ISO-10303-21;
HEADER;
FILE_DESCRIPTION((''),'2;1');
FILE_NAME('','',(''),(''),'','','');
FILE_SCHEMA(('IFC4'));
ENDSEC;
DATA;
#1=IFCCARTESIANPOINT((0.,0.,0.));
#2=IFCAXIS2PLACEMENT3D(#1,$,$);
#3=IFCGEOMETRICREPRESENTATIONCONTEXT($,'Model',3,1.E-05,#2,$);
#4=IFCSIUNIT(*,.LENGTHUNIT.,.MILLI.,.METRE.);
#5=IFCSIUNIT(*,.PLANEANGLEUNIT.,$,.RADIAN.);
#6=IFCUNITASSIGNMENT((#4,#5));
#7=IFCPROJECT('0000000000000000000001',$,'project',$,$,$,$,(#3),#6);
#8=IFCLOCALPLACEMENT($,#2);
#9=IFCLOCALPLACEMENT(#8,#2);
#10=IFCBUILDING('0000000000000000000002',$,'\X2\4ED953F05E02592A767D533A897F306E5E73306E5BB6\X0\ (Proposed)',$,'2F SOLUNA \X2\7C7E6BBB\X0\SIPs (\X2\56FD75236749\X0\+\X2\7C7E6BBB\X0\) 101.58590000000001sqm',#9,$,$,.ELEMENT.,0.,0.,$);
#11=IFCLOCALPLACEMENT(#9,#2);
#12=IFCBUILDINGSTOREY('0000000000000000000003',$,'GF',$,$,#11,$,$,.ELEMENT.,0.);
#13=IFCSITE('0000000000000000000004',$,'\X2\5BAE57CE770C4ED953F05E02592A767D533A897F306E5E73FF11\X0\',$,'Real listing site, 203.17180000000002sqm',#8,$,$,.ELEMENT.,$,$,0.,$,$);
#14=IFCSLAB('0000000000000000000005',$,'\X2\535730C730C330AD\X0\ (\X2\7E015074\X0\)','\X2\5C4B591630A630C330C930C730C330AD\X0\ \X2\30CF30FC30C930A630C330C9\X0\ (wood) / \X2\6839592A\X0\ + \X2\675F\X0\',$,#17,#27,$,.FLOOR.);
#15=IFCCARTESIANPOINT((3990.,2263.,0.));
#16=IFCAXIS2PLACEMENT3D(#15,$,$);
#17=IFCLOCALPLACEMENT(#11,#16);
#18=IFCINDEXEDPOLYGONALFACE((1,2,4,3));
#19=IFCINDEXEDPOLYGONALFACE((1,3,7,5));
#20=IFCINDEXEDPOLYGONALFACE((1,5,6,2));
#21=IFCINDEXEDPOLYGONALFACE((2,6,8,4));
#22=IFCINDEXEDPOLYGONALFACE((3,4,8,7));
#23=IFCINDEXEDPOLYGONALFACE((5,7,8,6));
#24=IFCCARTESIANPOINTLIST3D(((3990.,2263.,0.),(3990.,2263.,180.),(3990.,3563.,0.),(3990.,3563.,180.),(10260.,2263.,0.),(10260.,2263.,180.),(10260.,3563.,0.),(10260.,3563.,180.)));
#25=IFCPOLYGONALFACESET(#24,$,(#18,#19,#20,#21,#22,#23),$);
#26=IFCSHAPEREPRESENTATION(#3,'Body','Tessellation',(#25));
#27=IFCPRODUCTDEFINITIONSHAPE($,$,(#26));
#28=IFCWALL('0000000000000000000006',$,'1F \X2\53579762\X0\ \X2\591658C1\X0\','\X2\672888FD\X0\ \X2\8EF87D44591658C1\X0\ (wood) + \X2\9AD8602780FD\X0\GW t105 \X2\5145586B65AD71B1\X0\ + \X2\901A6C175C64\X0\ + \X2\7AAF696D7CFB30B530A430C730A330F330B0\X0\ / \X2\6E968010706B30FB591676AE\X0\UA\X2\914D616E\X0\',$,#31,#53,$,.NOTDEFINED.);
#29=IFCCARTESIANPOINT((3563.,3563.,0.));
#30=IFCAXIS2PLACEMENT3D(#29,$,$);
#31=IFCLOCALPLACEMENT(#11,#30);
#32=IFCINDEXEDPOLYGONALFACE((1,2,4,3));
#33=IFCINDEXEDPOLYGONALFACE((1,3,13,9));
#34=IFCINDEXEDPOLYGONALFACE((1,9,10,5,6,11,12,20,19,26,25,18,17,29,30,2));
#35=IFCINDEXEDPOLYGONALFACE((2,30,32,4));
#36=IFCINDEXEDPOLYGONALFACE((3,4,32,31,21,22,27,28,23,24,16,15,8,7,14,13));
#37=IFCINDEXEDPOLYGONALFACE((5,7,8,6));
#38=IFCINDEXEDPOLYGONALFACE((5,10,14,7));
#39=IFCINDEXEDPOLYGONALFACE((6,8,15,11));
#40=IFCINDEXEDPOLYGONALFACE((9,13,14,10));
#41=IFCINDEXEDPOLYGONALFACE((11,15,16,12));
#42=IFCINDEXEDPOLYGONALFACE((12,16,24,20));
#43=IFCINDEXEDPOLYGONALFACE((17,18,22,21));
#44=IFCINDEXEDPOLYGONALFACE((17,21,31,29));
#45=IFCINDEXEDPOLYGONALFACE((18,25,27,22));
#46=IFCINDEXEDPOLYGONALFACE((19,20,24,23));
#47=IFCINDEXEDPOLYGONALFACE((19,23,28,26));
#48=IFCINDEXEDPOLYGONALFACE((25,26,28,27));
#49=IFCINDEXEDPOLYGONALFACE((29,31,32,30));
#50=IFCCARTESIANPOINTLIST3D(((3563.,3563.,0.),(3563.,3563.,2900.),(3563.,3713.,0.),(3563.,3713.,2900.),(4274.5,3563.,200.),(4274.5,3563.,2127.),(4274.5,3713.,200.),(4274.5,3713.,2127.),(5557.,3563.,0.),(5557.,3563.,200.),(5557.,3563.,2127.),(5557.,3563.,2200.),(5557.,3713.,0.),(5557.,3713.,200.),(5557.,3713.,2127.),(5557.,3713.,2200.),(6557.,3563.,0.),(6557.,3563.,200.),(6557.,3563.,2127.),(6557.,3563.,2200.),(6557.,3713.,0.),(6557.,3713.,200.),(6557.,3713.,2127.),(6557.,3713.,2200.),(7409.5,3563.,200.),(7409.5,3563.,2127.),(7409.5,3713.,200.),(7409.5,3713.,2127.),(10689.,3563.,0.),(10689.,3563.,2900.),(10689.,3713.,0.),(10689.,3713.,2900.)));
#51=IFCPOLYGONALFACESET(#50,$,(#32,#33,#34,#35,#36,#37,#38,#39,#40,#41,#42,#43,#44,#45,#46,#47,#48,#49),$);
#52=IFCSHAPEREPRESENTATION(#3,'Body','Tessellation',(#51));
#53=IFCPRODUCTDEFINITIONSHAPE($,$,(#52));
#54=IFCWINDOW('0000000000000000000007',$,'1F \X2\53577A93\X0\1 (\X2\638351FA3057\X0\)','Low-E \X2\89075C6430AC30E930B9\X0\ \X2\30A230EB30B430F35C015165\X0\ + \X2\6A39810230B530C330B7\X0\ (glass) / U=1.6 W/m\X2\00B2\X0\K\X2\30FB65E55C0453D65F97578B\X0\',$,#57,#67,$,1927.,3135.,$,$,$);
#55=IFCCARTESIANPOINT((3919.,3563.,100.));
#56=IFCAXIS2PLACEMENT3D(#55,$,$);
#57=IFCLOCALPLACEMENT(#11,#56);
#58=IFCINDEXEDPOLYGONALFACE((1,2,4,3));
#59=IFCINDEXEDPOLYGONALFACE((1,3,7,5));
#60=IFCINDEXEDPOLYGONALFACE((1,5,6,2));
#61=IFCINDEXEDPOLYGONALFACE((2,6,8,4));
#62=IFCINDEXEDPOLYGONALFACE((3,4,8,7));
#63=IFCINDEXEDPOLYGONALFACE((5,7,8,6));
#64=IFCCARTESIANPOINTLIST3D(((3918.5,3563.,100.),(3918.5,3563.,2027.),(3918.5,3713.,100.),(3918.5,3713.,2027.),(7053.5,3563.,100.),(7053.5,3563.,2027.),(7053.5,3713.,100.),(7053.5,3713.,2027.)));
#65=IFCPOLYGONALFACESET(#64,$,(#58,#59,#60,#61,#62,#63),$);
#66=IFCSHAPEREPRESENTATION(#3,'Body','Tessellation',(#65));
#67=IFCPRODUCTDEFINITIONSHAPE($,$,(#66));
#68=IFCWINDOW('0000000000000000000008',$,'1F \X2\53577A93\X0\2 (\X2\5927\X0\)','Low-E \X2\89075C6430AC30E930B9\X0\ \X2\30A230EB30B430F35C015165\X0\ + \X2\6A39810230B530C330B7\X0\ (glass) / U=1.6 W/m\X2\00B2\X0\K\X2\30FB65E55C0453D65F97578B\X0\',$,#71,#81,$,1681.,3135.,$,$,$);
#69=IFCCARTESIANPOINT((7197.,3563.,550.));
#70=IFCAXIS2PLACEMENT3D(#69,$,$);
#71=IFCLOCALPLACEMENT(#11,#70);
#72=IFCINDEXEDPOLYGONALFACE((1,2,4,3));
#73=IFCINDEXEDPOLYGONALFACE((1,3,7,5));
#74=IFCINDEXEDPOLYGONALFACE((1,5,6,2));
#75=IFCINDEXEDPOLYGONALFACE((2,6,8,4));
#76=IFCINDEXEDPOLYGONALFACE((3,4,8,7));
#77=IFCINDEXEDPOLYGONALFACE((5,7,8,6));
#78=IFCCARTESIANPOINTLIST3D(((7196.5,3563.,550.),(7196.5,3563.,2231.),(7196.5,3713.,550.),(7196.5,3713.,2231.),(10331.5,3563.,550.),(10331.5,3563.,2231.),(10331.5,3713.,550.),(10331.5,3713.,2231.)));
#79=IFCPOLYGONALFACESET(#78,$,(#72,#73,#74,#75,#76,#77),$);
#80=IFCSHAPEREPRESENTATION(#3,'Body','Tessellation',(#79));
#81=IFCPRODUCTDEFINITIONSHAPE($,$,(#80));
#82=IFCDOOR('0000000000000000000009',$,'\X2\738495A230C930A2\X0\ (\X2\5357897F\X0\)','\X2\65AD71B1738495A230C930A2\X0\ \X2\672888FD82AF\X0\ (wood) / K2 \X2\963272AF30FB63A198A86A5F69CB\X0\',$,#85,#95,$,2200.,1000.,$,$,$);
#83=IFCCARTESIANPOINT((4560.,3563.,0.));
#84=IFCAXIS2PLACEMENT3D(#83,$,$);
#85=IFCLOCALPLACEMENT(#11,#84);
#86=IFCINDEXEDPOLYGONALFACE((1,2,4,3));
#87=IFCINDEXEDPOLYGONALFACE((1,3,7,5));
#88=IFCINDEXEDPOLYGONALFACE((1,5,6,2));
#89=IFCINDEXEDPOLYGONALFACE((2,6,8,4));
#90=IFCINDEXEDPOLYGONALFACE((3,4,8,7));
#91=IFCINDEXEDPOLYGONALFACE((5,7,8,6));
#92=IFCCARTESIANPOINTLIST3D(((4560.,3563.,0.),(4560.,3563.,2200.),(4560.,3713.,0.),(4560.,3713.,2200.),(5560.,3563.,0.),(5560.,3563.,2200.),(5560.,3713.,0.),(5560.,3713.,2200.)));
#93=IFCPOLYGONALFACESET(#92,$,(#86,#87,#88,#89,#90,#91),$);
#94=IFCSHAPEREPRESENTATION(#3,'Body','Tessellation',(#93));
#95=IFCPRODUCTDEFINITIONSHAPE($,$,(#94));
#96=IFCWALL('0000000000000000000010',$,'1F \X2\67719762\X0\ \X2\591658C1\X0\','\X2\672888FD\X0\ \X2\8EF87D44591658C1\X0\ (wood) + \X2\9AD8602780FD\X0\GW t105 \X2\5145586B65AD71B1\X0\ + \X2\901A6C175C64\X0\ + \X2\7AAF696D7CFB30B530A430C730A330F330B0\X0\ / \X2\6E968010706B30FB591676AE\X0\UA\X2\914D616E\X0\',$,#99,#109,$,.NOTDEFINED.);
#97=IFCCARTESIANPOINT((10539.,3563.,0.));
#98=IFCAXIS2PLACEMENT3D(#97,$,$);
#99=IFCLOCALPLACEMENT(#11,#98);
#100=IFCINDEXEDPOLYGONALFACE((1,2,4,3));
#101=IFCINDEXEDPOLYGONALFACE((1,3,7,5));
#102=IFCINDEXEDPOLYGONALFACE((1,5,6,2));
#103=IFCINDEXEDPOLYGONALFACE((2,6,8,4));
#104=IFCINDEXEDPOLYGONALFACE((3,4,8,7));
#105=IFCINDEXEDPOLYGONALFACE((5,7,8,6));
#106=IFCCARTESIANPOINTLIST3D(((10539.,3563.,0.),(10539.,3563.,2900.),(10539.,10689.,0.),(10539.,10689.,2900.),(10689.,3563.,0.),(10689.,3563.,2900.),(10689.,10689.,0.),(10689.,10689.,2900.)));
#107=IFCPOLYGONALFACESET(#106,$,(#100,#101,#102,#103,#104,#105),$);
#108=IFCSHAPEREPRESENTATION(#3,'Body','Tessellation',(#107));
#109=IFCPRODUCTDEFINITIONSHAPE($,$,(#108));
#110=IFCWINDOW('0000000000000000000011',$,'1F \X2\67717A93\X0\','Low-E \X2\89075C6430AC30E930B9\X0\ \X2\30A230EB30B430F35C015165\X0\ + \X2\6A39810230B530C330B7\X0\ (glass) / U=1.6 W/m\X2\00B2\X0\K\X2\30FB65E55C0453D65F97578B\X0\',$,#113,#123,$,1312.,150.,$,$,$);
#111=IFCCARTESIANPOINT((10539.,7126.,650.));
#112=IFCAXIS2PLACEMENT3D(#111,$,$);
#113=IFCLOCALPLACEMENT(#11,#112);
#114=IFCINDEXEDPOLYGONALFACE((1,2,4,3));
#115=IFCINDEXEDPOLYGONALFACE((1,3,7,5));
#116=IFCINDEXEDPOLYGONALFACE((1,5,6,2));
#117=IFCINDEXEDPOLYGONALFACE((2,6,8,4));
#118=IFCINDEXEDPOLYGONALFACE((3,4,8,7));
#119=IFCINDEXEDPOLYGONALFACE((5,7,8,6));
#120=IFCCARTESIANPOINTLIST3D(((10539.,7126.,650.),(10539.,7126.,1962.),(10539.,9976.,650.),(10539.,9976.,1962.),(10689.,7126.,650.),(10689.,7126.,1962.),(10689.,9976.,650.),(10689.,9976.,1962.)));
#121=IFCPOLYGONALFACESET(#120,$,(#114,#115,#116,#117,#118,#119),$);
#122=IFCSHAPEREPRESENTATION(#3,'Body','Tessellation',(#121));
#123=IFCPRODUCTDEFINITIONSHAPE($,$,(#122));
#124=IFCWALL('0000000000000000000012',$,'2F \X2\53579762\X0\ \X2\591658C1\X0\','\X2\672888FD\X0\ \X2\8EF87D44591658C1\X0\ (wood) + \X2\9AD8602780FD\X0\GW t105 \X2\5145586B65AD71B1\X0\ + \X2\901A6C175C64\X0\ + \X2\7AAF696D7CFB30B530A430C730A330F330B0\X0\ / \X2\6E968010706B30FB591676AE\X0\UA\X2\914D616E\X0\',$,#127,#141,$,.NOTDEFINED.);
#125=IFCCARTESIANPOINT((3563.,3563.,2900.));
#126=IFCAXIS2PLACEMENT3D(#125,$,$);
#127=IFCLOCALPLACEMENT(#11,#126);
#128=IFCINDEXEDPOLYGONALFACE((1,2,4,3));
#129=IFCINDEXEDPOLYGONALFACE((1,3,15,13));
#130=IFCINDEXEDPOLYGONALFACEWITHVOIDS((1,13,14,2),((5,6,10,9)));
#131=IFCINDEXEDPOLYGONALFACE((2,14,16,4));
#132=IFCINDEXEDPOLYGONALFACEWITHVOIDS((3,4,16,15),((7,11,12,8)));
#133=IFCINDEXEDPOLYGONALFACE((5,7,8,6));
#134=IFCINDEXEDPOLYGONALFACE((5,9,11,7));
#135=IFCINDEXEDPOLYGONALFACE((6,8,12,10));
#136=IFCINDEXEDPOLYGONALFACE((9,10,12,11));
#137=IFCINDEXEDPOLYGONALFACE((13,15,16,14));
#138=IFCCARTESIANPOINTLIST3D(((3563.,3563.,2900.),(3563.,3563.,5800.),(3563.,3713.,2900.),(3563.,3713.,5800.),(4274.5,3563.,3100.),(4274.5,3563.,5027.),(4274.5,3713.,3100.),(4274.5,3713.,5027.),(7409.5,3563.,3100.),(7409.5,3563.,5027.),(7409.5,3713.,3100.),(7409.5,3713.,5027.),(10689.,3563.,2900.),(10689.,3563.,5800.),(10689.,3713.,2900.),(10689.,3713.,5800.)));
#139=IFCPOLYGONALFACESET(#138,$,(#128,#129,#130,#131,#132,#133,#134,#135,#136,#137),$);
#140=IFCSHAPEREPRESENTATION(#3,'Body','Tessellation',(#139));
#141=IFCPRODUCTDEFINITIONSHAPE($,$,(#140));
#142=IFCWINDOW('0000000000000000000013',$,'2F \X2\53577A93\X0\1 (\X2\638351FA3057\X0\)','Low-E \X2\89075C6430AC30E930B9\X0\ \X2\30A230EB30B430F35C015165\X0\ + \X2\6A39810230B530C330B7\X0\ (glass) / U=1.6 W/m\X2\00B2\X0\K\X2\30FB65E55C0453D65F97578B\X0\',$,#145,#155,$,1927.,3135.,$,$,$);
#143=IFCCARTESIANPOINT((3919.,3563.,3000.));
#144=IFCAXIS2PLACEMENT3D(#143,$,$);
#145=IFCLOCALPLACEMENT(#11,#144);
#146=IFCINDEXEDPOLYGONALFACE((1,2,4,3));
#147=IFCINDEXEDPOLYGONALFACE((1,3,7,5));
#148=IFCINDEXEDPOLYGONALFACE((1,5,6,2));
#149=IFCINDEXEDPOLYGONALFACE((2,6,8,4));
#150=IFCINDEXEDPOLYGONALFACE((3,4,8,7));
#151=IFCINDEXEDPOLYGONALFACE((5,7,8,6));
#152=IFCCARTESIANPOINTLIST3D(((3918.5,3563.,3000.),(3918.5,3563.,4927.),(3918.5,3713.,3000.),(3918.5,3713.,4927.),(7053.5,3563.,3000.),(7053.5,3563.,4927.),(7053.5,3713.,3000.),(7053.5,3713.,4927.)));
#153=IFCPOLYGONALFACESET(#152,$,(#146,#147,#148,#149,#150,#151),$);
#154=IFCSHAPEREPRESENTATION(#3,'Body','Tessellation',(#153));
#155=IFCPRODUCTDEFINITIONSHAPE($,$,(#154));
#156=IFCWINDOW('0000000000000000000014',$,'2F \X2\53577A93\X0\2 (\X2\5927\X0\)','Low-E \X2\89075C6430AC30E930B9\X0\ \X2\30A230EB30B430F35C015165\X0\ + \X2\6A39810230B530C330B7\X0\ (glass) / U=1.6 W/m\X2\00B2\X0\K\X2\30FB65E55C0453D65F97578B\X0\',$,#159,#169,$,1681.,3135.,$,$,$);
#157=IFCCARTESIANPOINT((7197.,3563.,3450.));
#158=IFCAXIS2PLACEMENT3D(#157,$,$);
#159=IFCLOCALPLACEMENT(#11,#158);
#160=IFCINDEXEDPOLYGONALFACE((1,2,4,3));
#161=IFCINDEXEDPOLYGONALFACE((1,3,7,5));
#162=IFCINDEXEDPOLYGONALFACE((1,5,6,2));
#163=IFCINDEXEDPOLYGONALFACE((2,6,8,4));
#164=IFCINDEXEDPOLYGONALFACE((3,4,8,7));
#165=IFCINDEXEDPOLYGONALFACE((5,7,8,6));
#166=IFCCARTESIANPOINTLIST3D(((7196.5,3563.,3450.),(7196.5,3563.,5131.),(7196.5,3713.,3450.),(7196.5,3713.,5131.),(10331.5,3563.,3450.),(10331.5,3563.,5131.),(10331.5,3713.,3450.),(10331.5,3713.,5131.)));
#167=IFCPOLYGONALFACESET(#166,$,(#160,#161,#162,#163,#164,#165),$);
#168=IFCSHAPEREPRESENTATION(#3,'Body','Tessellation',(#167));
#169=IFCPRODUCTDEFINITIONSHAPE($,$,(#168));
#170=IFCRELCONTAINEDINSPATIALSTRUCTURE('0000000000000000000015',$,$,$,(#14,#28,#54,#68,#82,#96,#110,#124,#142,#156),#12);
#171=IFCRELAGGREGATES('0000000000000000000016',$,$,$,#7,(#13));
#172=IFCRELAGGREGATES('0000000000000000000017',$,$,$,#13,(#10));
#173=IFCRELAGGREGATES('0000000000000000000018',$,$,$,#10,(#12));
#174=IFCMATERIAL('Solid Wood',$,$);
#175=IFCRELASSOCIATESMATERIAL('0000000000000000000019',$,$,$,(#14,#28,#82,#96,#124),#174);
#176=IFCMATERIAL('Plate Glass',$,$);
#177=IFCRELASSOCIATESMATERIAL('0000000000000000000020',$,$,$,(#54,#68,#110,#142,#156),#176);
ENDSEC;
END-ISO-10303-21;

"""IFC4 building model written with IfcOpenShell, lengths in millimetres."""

from ifc_helpers import new_model, si_unit, frame, frame_2d, origin, place, context, project, spatial, rectangle, extrude, material, element, fill, save


model = new_model("IFC4")

# Units and contexts
model_context = context("Model", 3, precision=1e-05, world=origin())
ifc_project = project(units=[si_unit("LENGTHUNIT", "METRE", prefix="MILLI"), si_unit("PLANEANGLEUNIT", "RADIAN")], contexts=[model_context])

# Site, building, storey
site_placement = place(None, origin())
site = spatial("IfcSite", under=ifc_project, at=site_placement, Name="宮城県仙台市太白区西の平１", ObjectType="Real listing site, 203.17180000000002sqm", CompositionType="ELEMENT", RefElevation=0.0)
building_placement = place(site_placement, origin())
building = spatial("IfcBuilding", under=site, at=building_placement, Name="仙台市太白区西の平の家 (Proposed)", ObjectType="2F SOLUNA 籾殻SIPs (国産杉+籾殻) 101.58590000000001sqm", CompositionType="ELEMENT", ElevationOfRefHeight=0.0, ElevationOfTerrain=0.0)
storey_placement = place(building_placement, origin())
storey = spatial("IfcBuildingStorey", under=building, at=storey_placement, Name="GF", CompositionType="ELEMENT", Elevation=0.0)

# Slab
ifc_material_1 = material(Name="Solid Wood")
slab_1_placement = place(storey_placement, frame((3990.0, 2263.0, 0.0)))
element("IfcSlab", 1, at=slab_1_placement, inside=storey, material=ifc_material_1, Name="南デッキ (縁側)", Description="屋外ウッドデッキ ハードウッド (wood) / 根太 + 束", PredefinedType="FLOOR", context=model_context, shape_type="SweptSolid", body=[
    extrude(rectangle(XDim=6270.0, YDim=1300.0, at=frame_2d((3135.0, 650.0))), frame((3990.0, 2263.0, 0.0)), (0.0, 0.0, 1.0), 180.0),
])

# Wall, openings, windows, door
wall_1_placement = place(storey_placement, frame((3563.0, 3563.0, 0.0)))
wall_1 = element("IfcWall", 2, at=wall_1_placement, inside=storey, material=ifc_material_1, Name="1F 南面 外壁", Description="木製 軸組外壁 (wood) + 高性能GW t105 充填断熱 + 通気層 + 窯業系サイディング / 準耐火・外皮UA配慮", PredefinedType="NOTDEFINED", context=model_context, shape_type="SweptSolid", body=[
    extrude(rectangle(XDim=7126.0, YDim=150.0, at=frame_2d((3563.0, 75.0))), frame((3563.0, 3563.0, 0.0)), (0.0, 0.0, 1.0), 2900.0),
])
opening_1_placement = place(storey_placement, frame((3919.0, 3563.0, 100.0)))
opening_1 = element("IfcOpeningElement", 3, at=opening_1_placement, cuts=wall_1, PredefinedType="NOTDEFINED", context=model_context, shape_type="SweptSolid", body=[
    extrude(rectangle(XDim=3135.0, YDim=150.0, at=frame_2d((1567.0, 75.0))), frame((3919.0, 3563.0, 100.0)), (0.0, 0.0, 1.0), 1927.0),
])
opening_2_placement = place(storey_placement, frame((7197.0, 3563.0, 550.0)))
opening_2 = element("IfcOpeningElement", 4, at=opening_2_placement, cuts=wall_1, PredefinedType="NOTDEFINED", context=model_context, shape_type="SweptSolid", body=[
    extrude(rectangle(XDim=3135.0, YDim=150.0, at=frame_2d((1567.0, 75.0))), frame((7197.0, 3563.0, 550.0)), (0.0, 0.0, 1.0), 1681.0),
])
opening_3_placement = place(storey_placement, frame((4560.0, 3563.0, 0.0)))
opening_3 = element("IfcOpeningElement", 5, at=opening_3_placement, cuts=wall_1, PredefinedType="NOTDEFINED", context=model_context, shape_type="SweptSolid", body=[
    extrude(rectangle(XDim=1000.0, YDim=150.0, at=frame_2d((500.0, 75.0))), frame((4560.0, 3563.0, 0.0)), (0.0, 0.0, 1.0), 2200.0),
])
ifc_material_2 = material(Name="Plate Glass")
window_1_placement = place(storey_placement, frame((3919.0, 3563.0, 100.0)))
window_1 = element("IfcWindow", 6, at=window_1_placement, inside=storey, material=ifc_material_2, Name="1F 南窓1 (掃出し)", Description="Low-E 複層ガラス アルゴン封入 + 樹脂サッシ (glass) / U=1.6 W/m²K・日射取得型", OverallHeight=1927.0, OverallWidth=3135.0, context=model_context, shape_type="SweptSolid", body=[
    extrude(rectangle(XDim=3135.0, YDim=150.0, at=frame_2d((1567.0, 75.0))), frame((3919.0, 3563.0, 100.0)), (0.0, 0.0, 1.0), 1927.0),
])
fill(opening_1, window_1)
window_2_placement = place(storey_placement, frame((7197.0, 3563.0, 550.0)))
window_2 = element("IfcWindow", 7, at=window_2_placement, inside=storey, material=ifc_material_2, Name="1F 南窓2 (大)", Description="Low-E 複層ガラス アルゴン封入 + 樹脂サッシ (glass) / U=1.6 W/m²K・日射取得型", OverallHeight=1681.0, OverallWidth=3135.0, context=model_context, shape_type="SweptSolid", body=[
    extrude(rectangle(XDim=3135.0, YDim=150.0, at=frame_2d((1567.0, 75.0))), frame((7197.0, 3563.0, 550.0)), (0.0, 0.0, 1.0), 1681.0),
])
fill(opening_2, window_2)
door_placement = place(storey_placement, frame((4560.0, 3563.0, 0.0)))
door = element("IfcDoor", 8, at=door_placement, inside=storey, material=ifc_material_1, Name="玄関ドア (南西)", Description="断熱玄関ドア 木製芯 (wood) / K2 防犯・採風機構", OverallHeight=2200.0, OverallWidth=1000.0, context=model_context, shape_type="SweptSolid", body=[
    extrude(rectangle(XDim=1000.0, YDim=150.0, at=frame_2d((500.0, 75.0))), frame((4560.0, 3563.0, 0.0)), (0.0, 0.0, 1.0), 2200.0),
])
fill(opening_3, door)

# Wall, opening, window
wall_2_placement = place(storey_placement, frame((10539.0, 3563.0, 0.0)))
wall_2 = element("IfcWall", 9, at=wall_2_placement, inside=storey, material=ifc_material_1, Name="1F 東面 外壁", Description="木製 軸組外壁 (wood) + 高性能GW t105 充填断熱 + 通気層 + 窯業系サイディング / 準耐火・外皮UA配慮", PredefinedType="NOTDEFINED", context=model_context, shape_type="SweptSolid", body=[
    extrude(rectangle(XDim=150.0, YDim=7126.0, at=frame_2d((75.0, 3563.0))), frame((10539.0, 3563.0, 0.0)), (0.0, 0.0, 1.0), 2900.0),
])
opening_4_placement = place(storey_placement, frame((10539.0, 7126.0, 650.0)))
opening_4 = element("IfcOpeningElement", 10, at=opening_4_placement, cuts=wall_2, PredefinedType="NOTDEFINED", context=model_context, shape_type="SweptSolid", body=[
    extrude(rectangle(XDim=150.0, YDim=2850.0, at=frame_2d((75.0, 1425.0))), frame((10539.0, 7126.0, 650.0)), (0.0, 0.0, 1.0), 1312.0),
])
window_3_placement = place(storey_placement, frame((10539.0, 7126.0, 650.0)))
window_3 = element("IfcWindow", 11, at=window_3_placement, inside=storey, material=ifc_material_2, Name="1F 東窓", Description="Low-E 複層ガラス アルゴン封入 + 樹脂サッシ (glass) / U=1.6 W/m²K・日射取得型", OverallHeight=1312.0, OverallWidth=150.0, context=model_context, shape_type="SweptSolid", body=[
    extrude(rectangle(XDim=150.0, YDim=2850.0, at=frame_2d((75.0, 1425.0))), frame((10539.0, 7126.0, 650.0)), (0.0, 0.0, 1.0), 1312.0),
])
fill(opening_4, window_3)

# Wall, openings, windows
wall_3_placement = place(storey_placement, frame((3563.0, 3563.0, 2900.0)))
wall_3 = element("IfcWall", 12, at=wall_3_placement, inside=storey, material=ifc_material_1, Name="2F 南面 外壁", Description="木製 軸組外壁 (wood) + 高性能GW t105 充填断熱 + 通気層 + 窯業系サイディング / 準耐火・外皮UA配慮", PredefinedType="NOTDEFINED", context=model_context, shape_type="SweptSolid", body=[
    extrude(rectangle(XDim=7126.0, YDim=150.0, at=frame_2d((3563.0, 75.0))), frame((3563.0, 3563.0, 2900.0)), (0.0, 0.0, 1.0), 2900.0),
])
opening_5_placement = place(storey_placement, frame((3919.0, 3563.0, 3000.0)))
opening_5 = element("IfcOpeningElement", 13, at=opening_5_placement, cuts=wall_3, PredefinedType="NOTDEFINED", context=model_context, shape_type="SweptSolid", body=[
    extrude(rectangle(XDim=3135.0, YDim=150.0, at=frame_2d((1567.0, 75.0))), frame((3919.0, 3563.0, 3000.0)), (0.0, 0.0, 1.0), 1927.0),
])
opening_6_placement = place(storey_placement, frame((7197.0, 3563.0, 3450.0)))
opening_6 = element("IfcOpeningElement", 14, at=opening_6_placement, cuts=wall_3, PredefinedType="NOTDEFINED", context=model_context, shape_type="SweptSolid", body=[
    extrude(rectangle(XDim=3135.0, YDim=150.0, at=frame_2d((1567.0, 75.0))), frame((7197.0, 3563.0, 3450.0)), (0.0, 0.0, 1.0), 1681.0),
])
window_4_placement = place(storey_placement, frame((3919.0, 3563.0, 3000.0)))
window_4 = element("IfcWindow", 15, at=window_4_placement, inside=storey, material=ifc_material_2, Name="2F 南窓1 (掃出し)", Description="Low-E 複層ガラス アルゴン封入 + 樹脂サッシ (glass) / U=1.6 W/m²K・日射取得型", OverallHeight=1927.0, OverallWidth=3135.0, context=model_context, shape_type="SweptSolid", body=[
    extrude(rectangle(XDim=3135.0, YDim=150.0, at=frame_2d((1567.0, 75.0))), frame((3919.0, 3563.0, 3000.0)), (0.0, 0.0, 1.0), 1927.0),
])
fill(opening_5, window_4)
window_5_placement = place(storey_placement, frame((7197.0, 3563.0, 3450.0)))
window_5 = element("IfcWindow", 16, at=window_5_placement, inside=storey, material=ifc_material_2, Name="2F 南窓2 (大)", Description="Low-E 複層ガラス アルゴン封入 + 樹脂サッシ (glass) / U=1.6 W/m²K・日射取得型", OverallHeight=1681.0, OverallWidth=3135.0, context=model_context, shape_type="SweptSolid", body=[
    extrude(rectangle(XDim=3135.0, YDim=150.0, at=frame_2d((1567.0, 75.0))), frame((7197.0, 3563.0, 3450.0)), (0.0, 0.0, 1.0), 1681.0),
])
fill(opening_6, window_5)

save(model, "model.ifc")
